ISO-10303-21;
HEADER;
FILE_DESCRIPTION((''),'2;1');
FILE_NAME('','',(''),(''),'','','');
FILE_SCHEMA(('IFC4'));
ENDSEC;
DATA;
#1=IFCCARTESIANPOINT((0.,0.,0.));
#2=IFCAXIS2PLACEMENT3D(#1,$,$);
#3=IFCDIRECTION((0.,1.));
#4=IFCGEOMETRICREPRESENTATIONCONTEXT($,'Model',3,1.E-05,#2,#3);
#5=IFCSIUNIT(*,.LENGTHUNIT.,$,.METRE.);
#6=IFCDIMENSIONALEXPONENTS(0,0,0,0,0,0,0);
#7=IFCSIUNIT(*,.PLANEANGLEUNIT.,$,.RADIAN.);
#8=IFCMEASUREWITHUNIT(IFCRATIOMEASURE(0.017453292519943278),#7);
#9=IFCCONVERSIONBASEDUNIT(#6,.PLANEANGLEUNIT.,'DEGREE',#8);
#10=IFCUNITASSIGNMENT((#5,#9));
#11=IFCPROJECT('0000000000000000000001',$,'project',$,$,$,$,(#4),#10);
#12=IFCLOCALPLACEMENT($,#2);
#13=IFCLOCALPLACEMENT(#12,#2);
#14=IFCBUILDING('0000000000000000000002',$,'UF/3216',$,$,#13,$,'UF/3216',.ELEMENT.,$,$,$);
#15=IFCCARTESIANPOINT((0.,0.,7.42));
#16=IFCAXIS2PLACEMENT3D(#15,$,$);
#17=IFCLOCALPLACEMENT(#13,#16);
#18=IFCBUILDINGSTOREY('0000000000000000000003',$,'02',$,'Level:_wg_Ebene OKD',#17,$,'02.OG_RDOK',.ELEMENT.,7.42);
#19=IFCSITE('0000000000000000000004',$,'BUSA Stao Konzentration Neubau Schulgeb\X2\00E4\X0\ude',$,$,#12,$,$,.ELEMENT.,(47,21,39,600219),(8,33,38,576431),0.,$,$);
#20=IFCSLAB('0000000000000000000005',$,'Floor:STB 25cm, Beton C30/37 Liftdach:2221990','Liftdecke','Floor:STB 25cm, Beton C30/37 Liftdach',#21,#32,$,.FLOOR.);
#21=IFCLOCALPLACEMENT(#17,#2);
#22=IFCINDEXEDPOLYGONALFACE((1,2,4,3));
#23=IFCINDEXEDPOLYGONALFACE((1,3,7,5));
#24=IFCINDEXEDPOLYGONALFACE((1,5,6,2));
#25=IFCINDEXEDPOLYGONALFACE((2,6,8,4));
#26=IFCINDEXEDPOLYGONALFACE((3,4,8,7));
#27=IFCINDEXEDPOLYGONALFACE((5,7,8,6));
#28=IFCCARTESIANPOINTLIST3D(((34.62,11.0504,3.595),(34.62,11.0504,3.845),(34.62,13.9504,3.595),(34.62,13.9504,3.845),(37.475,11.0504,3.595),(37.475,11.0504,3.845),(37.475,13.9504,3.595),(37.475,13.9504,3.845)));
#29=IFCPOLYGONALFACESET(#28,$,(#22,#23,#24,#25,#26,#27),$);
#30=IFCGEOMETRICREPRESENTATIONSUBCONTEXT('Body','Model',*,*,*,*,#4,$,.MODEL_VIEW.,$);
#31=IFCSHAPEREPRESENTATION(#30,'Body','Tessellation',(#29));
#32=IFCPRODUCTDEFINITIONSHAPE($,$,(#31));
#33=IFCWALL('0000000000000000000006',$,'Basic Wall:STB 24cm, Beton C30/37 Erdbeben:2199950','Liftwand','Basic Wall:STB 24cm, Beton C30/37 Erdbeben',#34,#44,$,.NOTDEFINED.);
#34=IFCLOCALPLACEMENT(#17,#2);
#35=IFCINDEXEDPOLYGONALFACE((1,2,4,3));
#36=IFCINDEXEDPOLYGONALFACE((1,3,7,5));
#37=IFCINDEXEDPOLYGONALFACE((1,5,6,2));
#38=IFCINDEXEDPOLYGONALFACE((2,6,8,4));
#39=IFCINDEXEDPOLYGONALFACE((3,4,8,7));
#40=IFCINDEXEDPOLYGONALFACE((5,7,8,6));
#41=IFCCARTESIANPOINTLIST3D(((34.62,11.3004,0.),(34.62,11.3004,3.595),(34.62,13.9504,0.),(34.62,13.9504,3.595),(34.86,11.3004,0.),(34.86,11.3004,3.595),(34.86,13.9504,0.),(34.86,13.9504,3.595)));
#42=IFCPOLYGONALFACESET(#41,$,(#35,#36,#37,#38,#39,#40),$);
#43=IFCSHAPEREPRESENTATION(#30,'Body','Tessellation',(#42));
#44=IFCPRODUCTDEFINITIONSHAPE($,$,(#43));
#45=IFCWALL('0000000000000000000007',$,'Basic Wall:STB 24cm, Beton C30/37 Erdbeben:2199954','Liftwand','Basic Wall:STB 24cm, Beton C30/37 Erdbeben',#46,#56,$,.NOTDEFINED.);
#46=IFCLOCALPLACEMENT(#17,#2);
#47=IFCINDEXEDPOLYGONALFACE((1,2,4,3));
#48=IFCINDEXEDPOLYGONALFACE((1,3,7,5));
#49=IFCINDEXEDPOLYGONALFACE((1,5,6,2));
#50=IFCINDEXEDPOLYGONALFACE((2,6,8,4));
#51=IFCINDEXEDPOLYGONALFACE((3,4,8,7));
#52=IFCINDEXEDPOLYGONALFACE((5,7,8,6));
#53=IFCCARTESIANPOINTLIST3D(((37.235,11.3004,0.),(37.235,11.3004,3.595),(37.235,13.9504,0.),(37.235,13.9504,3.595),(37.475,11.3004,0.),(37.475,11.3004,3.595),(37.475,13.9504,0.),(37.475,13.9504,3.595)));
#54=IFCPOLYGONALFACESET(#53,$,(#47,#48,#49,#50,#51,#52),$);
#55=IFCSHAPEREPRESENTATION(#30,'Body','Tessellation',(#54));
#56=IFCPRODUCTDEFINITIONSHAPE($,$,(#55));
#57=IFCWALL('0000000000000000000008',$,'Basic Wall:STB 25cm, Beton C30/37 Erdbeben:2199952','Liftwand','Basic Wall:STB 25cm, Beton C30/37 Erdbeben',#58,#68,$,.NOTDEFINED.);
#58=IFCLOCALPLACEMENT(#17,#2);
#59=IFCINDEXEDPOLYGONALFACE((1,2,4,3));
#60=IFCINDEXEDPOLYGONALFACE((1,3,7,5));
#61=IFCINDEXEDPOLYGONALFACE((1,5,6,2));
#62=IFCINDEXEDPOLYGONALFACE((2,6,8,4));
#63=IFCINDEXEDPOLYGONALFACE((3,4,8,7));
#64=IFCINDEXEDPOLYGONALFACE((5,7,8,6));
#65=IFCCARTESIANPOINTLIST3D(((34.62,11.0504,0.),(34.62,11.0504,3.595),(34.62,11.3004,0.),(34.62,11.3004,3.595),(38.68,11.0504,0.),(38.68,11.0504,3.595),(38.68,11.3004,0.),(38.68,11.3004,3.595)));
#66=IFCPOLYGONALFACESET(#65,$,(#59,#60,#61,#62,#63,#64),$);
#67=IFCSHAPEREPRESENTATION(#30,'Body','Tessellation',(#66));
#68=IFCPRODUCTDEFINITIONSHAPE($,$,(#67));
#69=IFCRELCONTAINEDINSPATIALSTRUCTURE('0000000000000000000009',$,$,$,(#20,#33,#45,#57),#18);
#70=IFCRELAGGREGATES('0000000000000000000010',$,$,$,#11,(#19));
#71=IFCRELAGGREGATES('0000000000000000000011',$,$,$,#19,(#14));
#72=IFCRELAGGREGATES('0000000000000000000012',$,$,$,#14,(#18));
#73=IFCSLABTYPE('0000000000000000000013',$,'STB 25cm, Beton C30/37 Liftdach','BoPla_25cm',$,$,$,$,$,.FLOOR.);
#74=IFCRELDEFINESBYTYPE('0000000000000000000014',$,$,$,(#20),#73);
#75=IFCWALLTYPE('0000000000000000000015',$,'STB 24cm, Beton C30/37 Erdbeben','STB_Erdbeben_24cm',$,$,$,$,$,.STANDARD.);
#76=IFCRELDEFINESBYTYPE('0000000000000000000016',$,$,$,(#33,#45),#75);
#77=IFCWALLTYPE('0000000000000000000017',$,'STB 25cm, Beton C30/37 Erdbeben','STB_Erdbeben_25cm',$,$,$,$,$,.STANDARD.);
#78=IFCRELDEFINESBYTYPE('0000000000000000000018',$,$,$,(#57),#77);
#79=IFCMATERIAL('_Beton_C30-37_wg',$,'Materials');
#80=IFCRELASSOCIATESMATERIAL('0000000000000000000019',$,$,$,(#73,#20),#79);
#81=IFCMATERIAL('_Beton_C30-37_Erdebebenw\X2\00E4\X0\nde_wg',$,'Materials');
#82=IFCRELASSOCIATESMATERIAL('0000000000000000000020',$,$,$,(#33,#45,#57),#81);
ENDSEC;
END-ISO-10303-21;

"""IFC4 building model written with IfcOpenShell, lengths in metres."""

from ifc_helpers import new_model, entity, si_unit, converted_unit, direction, frame, origin, place, context, subcontext, project, spatial, indexed_curve, outline, extrude, material, type_object, element, save


model = new_model("IFC4")

# Units and contexts
model_context = context("Model", 3, precision=1e-05, world=origin(), true_north=direction((0.0, 1.0)))
body_context = subcontext(model_context, "Body", "Model", "MODEL_VIEW")
ifc_project = project(units=[si_unit("LENGTHUNIT", "METRE"), converted_unit("PLANEANGLEUNIT", "DEGREE", entity("IfcRatioMeasure", 0.017453292519943278), si_unit("PLANEANGLEUNIT", "RADIAN"), dimensions=[0, 0, 0, 0, 0, 0, 0])], contexts=[model_context])

# Site, building, storey
site_placement = place(None, origin())
site = spatial("IfcSite", under=ifc_project, at=site_placement, Name="BUSA Stao Konzentration Neubau Schulgebäude", CompositionType="ELEMENT", RefLatitude=(47, 21, 39, 600219), RefLongitude=(8, 33, 38, 576431), RefElevation=0.0)
building_placement = place(site_placement, origin())
building = spatial("IfcBuilding", under=site, at=building_placement, Name="UF/3216", LongName="UF/3216", CompositionType="ELEMENT")
storey_placement = place(building_placement, frame((0.0, 0.0, 7.42)))
storey = spatial("IfcBuildingStorey", under=building, at=storey_placement, Name="02", ObjectType="Level:_wg_Ebene OKD", LongName="02.OG_RDOK", CompositionType="ELEMENT", Elevation=7.42)

# Slab
ifc_material_1 = material(Name="_Beton_C30-37_wg", Category="Materials")
slab_type = type_object("IfcSlabType", Name="STB 25cm, Beton C30/37 Liftdach", Description="BoPla_25cm", PredefinedType="FLOOR", material=ifc_material_1)
slab_placement = place(storey_placement, origin())
element("IfcSlab", 1, at=slab_placement, inside=storey, type_object=slab_type, material=ifc_material_1, Name="Floor:STB 25cm, Beton C30/37 Liftdach:2221990", Description="Liftdecke", ObjectType="Floor:STB 25cm, Beton C30/37 Liftdach", PredefinedType="FLOOR", context=body_context, shape_type="SweptSolid", body=[
    extrude(outline(indexed_curve([(-1.45, -1.4275), (1.45, -1.4275), (1.45, 1.4275), (-1.45, 1.4275), (-1.45, -1.4275)], self_intersect=False)), frame((36.0475, 12.5004, 3.845), z_axis=(0.0, 0.0, -1.0), x_axis=(0.0, 1.0, 0.0)), (0.0, 0.0, 1.0), 0.25),
])

# Walls
ifc_material_2 = material(Name="_Beton_C30-37_Erdebebenwände_wg", Category="Materials")
wall_type_1 = type_object("IfcWallType", Name="STB 24cm, Beton C30/37 Erdbeben", Description="STB_Erdbeben_24cm", PredefinedType="STANDARD")
for number, where, z_axis, x_axis, name in (
    (2, (34.74, 11.3004, 0.0), (0.0, 0.0, 1.0), (0.0, 1.0, 0.0), "Basic Wall:STB 24cm, Beton C30/37 Erdbeben:2199950"),
    (3, (37.355, 13.9504, 0.0), (0.0, 0.0, 1.0), (0.0, -1.0, 0.0), "Basic Wall:STB 24cm, Beton C30/37 Erdbeben:2199954"),
):
    element("IfcWall", number, at=place(storey_placement, frame(where, z_axis=z_axis, x_axis=x_axis)), inside=storey, type_object=wall_type_1, material=ifc_material_2, Name=name, Description="Liftwand", ObjectType="Basic Wall:STB 24cm, Beton C30/37 Erdbeben", PredefinedType="NOTDEFINED", context=body_context, shape_type="SweptSolid", body=[
        extrude(outline(indexed_curve([(2.65, 0.12), (0.0, 0.12), (0.0, -0.12), (2.65, -0.12), (2.65, 0.12)], self_intersect=False)), origin(), (0.0, 0.0, 1.0), 3.595),
    ])
wall_type_2 = type_object("IfcWallType", Name="STB 25cm, Beton C30/37 Erdbeben", Description="STB_Erdbeben_25cm", PredefinedType="STANDARD")
wall_placement = place(storey_placement, frame((38.68, 11.1754, 0.0), z_axis=(0.0, 0.0, 1.0), x_axis=(-1.0, 0.0, 0.0)))
element("IfcWall", 4, at=wall_placement, inside=storey, type_object=wall_type_2, material=ifc_material_2, Name="Basic Wall:STB 25cm, Beton C30/37 Erdbeben:2199952", Description="Liftwand", ObjectType="Basic Wall:STB 25cm, Beton C30/37 Erdbeben", PredefinedType="NOTDEFINED", context=body_context, shape_type="SweptSolid", body=[
    extrude(outline(indexed_curve([(4.06, 0.125), (0.0, 0.125), (0.0, -0.125), (4.06, -0.125), (4.06, 0.125)], self_intersect=False)), origin(), (0.0, 0.0, 1.0), 3.595),
])

save(model, "model.ifc")
